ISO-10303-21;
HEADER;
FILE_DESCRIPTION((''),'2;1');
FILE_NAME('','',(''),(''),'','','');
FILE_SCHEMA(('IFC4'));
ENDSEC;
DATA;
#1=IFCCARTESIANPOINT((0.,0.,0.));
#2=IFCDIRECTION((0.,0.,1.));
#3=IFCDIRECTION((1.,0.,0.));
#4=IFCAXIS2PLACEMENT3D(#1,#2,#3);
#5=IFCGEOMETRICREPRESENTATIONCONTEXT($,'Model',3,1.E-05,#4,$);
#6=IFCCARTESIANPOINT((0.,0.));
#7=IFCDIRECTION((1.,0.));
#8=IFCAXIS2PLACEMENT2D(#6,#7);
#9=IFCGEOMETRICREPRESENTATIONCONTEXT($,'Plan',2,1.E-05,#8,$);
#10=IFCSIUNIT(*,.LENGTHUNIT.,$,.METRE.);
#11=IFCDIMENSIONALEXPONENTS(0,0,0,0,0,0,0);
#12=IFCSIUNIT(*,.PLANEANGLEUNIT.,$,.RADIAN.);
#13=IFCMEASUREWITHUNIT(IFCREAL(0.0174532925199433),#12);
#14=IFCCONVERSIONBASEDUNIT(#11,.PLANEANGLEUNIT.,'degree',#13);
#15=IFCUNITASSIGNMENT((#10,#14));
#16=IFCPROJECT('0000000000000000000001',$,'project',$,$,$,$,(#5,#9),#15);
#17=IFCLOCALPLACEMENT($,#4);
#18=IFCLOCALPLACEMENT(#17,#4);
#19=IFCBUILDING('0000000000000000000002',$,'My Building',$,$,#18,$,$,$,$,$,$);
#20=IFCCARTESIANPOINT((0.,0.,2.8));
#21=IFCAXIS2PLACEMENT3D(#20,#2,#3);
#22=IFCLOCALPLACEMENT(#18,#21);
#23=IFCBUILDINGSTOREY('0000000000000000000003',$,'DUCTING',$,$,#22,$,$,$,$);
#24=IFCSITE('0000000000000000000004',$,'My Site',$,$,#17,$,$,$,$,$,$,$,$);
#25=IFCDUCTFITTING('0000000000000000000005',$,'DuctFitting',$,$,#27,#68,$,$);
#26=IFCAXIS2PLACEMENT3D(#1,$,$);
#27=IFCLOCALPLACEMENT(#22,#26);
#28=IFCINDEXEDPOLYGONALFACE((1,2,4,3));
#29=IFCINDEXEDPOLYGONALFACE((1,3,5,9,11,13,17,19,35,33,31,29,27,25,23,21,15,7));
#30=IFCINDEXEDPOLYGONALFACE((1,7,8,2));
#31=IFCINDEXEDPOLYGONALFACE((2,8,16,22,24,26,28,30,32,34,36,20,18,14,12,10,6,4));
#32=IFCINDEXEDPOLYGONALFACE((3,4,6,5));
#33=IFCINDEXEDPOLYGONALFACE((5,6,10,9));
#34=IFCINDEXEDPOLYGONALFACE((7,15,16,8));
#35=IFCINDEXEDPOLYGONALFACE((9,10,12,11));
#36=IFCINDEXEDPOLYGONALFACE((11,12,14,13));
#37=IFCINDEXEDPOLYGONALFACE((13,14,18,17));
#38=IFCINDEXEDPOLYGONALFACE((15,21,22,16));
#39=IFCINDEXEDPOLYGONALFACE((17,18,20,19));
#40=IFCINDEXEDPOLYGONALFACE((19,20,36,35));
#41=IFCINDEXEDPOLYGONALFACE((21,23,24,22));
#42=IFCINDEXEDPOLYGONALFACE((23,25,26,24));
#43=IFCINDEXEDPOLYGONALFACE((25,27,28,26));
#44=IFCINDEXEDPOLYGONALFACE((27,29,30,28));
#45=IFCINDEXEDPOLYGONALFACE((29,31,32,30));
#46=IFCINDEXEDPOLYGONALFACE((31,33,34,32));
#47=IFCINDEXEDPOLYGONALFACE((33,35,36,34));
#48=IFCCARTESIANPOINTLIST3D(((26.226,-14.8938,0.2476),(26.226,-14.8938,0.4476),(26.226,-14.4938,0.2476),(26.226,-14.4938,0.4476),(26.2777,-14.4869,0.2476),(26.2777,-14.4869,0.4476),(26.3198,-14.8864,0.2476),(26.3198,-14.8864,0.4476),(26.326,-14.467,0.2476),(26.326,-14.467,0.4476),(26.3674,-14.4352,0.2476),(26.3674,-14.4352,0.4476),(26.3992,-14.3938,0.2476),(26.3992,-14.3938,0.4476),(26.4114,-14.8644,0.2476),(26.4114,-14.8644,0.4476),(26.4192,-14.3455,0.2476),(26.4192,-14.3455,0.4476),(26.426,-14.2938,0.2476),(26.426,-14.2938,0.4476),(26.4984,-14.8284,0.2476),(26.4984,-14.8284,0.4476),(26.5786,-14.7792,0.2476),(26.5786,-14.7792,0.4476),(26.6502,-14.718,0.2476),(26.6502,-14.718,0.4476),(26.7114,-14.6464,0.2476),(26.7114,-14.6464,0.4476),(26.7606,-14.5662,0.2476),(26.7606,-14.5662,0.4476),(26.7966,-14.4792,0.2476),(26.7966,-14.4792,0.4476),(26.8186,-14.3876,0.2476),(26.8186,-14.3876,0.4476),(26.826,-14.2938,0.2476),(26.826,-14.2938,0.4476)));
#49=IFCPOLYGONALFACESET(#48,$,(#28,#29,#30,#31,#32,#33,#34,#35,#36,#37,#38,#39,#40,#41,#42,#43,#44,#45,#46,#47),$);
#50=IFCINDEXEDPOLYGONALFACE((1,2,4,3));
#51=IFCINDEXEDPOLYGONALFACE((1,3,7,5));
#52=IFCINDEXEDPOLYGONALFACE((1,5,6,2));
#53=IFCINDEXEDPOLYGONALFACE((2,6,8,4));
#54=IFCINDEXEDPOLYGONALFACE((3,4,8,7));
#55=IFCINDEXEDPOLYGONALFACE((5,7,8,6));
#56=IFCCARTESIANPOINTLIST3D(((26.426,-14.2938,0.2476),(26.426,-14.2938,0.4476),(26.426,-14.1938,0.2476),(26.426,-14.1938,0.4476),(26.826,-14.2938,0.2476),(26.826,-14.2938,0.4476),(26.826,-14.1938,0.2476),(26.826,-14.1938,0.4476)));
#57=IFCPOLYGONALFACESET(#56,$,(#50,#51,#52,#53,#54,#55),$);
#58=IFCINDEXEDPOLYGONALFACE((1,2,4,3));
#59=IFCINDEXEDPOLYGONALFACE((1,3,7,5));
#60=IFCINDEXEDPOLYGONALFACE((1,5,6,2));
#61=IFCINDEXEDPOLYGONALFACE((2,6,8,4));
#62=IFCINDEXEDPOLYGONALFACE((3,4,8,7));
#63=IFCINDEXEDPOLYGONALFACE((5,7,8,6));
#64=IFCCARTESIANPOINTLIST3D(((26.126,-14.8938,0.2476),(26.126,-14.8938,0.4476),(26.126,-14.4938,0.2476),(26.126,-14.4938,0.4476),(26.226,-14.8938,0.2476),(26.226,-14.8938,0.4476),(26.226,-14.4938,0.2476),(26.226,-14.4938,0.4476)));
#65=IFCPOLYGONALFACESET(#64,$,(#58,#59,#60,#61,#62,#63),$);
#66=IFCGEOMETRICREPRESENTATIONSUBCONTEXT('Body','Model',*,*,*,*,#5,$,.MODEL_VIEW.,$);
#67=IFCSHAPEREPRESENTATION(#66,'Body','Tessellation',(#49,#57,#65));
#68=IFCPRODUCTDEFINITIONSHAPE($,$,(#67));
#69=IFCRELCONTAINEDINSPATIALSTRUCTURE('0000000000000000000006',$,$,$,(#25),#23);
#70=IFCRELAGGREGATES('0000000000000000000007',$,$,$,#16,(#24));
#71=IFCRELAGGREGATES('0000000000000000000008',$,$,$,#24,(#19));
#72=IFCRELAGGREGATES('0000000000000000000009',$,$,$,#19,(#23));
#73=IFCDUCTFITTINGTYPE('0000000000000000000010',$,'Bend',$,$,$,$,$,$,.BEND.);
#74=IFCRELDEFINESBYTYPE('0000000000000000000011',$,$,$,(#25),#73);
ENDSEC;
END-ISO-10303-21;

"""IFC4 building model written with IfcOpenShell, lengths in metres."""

from ifc_helpers import new_model, entity, si_unit, converted_unit, frame, origin_with_axes, origin_2d_with_axis, place, context, subcontext, project, spatial, line, arc, indexed_curve, rectangle, outline, extrude, source, transform, mapped, type_object, type_shapes, element, save


model = new_model("IFC4")

# Units and contexts
model_context = context("Model", 3, precision=1e-05, world=origin_with_axes())
plan_context = context("Plan", 2, precision=1e-05, world=origin_2d_with_axis())
body_context = subcontext(model_context, "Body", "Model", "MODEL_VIEW")
ifc_project = project(units=[si_unit("LENGTHUNIT", "METRE"), converted_unit("PLANEANGLEUNIT", "degree", entity("IfcReal", 0.0174532925199433), si_unit("PLANEANGLEUNIT", "RADIAN"), dimensions=[0, 0, 0, 0, 0, 0, 0])], contexts=[model_context, plan_context])

# Site, building, storey
site_placement = place(None, origin_with_axes())
site = spatial("IfcSite", under=ifc_project, at=site_placement, Name="My Site")
building_placement = place(site_placement, origin_with_axes())
building = spatial("IfcBuilding", under=site, at=building_placement, Name="My Building")
storey_placement = place(building_placement, frame((0.0, 0.0, 2.8), z_axis=(0.0, 0.0, 1.0), x_axis=(1.0, 0.0, 0.0)))
storey = spatial("IfcBuildingStorey", under=building, at=storey_placement, Name="DUCTING")

# Duct fitting
duct_fitting_type_1 = type_object("IfcDuctFittingType", Name="Bend", PredefinedType="BEND")
shared_shape = source(origin_with_axes(), body_context, "Body", "SweptSolid", [
    extrude(outline(indexed_curve([(0.2, 0.0), (0.2586, -0.1414), (0.4, -0.2), (0.4, -0.6), (-0.0243, -0.4243), (-0.2, 0.0)], segments=[arc(1, 2, 3), line(3, 4), arc(4, 5, 6), line(6, 1)])), frame((0.0, -0.1, -0.1), z_axis=(0.0, -1.0, 0.0), x_axis=(1.0, 0.0, 0.0)), (0.0, 0.0, -1.0), 0.2),
    extrude(rectangle(XDim=0.4, YDim=0.2), origin_with_axes(), (0.0, 0.0, -1.0), 0.1),
    extrude(rectangle(XDim=0.4, YDim=0.2), frame((0.4, 0.0, -0.5), z_axis=(1.0, 0.0, 0.0), x_axis=(0.0, 0.0, 1.0)), (0.0, 0.0, 1.0), 0.1),
])
type_shapes(duct_fitting_type_1, [shared_shape])
for number, where, z_axis, x_axis, name in (
    (1, (26.626, -14.1938, 0.3476), (0.0, 1.0, 0.0), (-1.0, 0.0, 0.0), "DuctFitting"),
):
    element("IfcDuctFitting", number, at=place(storey_placement, frame(where, z_axis=z_axis, x_axis=x_axis)), inside=storey, type_object=duct_fitting_type_1, Name=name, context=body_context, shape_type="MappedRepresentation", body=[
        mapped(shared_shape, transform((0.0, 0.0, 0.0), x_axis=(1.0, 0.0, 0.0), y_axis=(0.0, 1.0, 0.0), z_axis=(0.0, 0.0, 1.0), scale=1.0)),
    ])

save(model, "model.ifc")
